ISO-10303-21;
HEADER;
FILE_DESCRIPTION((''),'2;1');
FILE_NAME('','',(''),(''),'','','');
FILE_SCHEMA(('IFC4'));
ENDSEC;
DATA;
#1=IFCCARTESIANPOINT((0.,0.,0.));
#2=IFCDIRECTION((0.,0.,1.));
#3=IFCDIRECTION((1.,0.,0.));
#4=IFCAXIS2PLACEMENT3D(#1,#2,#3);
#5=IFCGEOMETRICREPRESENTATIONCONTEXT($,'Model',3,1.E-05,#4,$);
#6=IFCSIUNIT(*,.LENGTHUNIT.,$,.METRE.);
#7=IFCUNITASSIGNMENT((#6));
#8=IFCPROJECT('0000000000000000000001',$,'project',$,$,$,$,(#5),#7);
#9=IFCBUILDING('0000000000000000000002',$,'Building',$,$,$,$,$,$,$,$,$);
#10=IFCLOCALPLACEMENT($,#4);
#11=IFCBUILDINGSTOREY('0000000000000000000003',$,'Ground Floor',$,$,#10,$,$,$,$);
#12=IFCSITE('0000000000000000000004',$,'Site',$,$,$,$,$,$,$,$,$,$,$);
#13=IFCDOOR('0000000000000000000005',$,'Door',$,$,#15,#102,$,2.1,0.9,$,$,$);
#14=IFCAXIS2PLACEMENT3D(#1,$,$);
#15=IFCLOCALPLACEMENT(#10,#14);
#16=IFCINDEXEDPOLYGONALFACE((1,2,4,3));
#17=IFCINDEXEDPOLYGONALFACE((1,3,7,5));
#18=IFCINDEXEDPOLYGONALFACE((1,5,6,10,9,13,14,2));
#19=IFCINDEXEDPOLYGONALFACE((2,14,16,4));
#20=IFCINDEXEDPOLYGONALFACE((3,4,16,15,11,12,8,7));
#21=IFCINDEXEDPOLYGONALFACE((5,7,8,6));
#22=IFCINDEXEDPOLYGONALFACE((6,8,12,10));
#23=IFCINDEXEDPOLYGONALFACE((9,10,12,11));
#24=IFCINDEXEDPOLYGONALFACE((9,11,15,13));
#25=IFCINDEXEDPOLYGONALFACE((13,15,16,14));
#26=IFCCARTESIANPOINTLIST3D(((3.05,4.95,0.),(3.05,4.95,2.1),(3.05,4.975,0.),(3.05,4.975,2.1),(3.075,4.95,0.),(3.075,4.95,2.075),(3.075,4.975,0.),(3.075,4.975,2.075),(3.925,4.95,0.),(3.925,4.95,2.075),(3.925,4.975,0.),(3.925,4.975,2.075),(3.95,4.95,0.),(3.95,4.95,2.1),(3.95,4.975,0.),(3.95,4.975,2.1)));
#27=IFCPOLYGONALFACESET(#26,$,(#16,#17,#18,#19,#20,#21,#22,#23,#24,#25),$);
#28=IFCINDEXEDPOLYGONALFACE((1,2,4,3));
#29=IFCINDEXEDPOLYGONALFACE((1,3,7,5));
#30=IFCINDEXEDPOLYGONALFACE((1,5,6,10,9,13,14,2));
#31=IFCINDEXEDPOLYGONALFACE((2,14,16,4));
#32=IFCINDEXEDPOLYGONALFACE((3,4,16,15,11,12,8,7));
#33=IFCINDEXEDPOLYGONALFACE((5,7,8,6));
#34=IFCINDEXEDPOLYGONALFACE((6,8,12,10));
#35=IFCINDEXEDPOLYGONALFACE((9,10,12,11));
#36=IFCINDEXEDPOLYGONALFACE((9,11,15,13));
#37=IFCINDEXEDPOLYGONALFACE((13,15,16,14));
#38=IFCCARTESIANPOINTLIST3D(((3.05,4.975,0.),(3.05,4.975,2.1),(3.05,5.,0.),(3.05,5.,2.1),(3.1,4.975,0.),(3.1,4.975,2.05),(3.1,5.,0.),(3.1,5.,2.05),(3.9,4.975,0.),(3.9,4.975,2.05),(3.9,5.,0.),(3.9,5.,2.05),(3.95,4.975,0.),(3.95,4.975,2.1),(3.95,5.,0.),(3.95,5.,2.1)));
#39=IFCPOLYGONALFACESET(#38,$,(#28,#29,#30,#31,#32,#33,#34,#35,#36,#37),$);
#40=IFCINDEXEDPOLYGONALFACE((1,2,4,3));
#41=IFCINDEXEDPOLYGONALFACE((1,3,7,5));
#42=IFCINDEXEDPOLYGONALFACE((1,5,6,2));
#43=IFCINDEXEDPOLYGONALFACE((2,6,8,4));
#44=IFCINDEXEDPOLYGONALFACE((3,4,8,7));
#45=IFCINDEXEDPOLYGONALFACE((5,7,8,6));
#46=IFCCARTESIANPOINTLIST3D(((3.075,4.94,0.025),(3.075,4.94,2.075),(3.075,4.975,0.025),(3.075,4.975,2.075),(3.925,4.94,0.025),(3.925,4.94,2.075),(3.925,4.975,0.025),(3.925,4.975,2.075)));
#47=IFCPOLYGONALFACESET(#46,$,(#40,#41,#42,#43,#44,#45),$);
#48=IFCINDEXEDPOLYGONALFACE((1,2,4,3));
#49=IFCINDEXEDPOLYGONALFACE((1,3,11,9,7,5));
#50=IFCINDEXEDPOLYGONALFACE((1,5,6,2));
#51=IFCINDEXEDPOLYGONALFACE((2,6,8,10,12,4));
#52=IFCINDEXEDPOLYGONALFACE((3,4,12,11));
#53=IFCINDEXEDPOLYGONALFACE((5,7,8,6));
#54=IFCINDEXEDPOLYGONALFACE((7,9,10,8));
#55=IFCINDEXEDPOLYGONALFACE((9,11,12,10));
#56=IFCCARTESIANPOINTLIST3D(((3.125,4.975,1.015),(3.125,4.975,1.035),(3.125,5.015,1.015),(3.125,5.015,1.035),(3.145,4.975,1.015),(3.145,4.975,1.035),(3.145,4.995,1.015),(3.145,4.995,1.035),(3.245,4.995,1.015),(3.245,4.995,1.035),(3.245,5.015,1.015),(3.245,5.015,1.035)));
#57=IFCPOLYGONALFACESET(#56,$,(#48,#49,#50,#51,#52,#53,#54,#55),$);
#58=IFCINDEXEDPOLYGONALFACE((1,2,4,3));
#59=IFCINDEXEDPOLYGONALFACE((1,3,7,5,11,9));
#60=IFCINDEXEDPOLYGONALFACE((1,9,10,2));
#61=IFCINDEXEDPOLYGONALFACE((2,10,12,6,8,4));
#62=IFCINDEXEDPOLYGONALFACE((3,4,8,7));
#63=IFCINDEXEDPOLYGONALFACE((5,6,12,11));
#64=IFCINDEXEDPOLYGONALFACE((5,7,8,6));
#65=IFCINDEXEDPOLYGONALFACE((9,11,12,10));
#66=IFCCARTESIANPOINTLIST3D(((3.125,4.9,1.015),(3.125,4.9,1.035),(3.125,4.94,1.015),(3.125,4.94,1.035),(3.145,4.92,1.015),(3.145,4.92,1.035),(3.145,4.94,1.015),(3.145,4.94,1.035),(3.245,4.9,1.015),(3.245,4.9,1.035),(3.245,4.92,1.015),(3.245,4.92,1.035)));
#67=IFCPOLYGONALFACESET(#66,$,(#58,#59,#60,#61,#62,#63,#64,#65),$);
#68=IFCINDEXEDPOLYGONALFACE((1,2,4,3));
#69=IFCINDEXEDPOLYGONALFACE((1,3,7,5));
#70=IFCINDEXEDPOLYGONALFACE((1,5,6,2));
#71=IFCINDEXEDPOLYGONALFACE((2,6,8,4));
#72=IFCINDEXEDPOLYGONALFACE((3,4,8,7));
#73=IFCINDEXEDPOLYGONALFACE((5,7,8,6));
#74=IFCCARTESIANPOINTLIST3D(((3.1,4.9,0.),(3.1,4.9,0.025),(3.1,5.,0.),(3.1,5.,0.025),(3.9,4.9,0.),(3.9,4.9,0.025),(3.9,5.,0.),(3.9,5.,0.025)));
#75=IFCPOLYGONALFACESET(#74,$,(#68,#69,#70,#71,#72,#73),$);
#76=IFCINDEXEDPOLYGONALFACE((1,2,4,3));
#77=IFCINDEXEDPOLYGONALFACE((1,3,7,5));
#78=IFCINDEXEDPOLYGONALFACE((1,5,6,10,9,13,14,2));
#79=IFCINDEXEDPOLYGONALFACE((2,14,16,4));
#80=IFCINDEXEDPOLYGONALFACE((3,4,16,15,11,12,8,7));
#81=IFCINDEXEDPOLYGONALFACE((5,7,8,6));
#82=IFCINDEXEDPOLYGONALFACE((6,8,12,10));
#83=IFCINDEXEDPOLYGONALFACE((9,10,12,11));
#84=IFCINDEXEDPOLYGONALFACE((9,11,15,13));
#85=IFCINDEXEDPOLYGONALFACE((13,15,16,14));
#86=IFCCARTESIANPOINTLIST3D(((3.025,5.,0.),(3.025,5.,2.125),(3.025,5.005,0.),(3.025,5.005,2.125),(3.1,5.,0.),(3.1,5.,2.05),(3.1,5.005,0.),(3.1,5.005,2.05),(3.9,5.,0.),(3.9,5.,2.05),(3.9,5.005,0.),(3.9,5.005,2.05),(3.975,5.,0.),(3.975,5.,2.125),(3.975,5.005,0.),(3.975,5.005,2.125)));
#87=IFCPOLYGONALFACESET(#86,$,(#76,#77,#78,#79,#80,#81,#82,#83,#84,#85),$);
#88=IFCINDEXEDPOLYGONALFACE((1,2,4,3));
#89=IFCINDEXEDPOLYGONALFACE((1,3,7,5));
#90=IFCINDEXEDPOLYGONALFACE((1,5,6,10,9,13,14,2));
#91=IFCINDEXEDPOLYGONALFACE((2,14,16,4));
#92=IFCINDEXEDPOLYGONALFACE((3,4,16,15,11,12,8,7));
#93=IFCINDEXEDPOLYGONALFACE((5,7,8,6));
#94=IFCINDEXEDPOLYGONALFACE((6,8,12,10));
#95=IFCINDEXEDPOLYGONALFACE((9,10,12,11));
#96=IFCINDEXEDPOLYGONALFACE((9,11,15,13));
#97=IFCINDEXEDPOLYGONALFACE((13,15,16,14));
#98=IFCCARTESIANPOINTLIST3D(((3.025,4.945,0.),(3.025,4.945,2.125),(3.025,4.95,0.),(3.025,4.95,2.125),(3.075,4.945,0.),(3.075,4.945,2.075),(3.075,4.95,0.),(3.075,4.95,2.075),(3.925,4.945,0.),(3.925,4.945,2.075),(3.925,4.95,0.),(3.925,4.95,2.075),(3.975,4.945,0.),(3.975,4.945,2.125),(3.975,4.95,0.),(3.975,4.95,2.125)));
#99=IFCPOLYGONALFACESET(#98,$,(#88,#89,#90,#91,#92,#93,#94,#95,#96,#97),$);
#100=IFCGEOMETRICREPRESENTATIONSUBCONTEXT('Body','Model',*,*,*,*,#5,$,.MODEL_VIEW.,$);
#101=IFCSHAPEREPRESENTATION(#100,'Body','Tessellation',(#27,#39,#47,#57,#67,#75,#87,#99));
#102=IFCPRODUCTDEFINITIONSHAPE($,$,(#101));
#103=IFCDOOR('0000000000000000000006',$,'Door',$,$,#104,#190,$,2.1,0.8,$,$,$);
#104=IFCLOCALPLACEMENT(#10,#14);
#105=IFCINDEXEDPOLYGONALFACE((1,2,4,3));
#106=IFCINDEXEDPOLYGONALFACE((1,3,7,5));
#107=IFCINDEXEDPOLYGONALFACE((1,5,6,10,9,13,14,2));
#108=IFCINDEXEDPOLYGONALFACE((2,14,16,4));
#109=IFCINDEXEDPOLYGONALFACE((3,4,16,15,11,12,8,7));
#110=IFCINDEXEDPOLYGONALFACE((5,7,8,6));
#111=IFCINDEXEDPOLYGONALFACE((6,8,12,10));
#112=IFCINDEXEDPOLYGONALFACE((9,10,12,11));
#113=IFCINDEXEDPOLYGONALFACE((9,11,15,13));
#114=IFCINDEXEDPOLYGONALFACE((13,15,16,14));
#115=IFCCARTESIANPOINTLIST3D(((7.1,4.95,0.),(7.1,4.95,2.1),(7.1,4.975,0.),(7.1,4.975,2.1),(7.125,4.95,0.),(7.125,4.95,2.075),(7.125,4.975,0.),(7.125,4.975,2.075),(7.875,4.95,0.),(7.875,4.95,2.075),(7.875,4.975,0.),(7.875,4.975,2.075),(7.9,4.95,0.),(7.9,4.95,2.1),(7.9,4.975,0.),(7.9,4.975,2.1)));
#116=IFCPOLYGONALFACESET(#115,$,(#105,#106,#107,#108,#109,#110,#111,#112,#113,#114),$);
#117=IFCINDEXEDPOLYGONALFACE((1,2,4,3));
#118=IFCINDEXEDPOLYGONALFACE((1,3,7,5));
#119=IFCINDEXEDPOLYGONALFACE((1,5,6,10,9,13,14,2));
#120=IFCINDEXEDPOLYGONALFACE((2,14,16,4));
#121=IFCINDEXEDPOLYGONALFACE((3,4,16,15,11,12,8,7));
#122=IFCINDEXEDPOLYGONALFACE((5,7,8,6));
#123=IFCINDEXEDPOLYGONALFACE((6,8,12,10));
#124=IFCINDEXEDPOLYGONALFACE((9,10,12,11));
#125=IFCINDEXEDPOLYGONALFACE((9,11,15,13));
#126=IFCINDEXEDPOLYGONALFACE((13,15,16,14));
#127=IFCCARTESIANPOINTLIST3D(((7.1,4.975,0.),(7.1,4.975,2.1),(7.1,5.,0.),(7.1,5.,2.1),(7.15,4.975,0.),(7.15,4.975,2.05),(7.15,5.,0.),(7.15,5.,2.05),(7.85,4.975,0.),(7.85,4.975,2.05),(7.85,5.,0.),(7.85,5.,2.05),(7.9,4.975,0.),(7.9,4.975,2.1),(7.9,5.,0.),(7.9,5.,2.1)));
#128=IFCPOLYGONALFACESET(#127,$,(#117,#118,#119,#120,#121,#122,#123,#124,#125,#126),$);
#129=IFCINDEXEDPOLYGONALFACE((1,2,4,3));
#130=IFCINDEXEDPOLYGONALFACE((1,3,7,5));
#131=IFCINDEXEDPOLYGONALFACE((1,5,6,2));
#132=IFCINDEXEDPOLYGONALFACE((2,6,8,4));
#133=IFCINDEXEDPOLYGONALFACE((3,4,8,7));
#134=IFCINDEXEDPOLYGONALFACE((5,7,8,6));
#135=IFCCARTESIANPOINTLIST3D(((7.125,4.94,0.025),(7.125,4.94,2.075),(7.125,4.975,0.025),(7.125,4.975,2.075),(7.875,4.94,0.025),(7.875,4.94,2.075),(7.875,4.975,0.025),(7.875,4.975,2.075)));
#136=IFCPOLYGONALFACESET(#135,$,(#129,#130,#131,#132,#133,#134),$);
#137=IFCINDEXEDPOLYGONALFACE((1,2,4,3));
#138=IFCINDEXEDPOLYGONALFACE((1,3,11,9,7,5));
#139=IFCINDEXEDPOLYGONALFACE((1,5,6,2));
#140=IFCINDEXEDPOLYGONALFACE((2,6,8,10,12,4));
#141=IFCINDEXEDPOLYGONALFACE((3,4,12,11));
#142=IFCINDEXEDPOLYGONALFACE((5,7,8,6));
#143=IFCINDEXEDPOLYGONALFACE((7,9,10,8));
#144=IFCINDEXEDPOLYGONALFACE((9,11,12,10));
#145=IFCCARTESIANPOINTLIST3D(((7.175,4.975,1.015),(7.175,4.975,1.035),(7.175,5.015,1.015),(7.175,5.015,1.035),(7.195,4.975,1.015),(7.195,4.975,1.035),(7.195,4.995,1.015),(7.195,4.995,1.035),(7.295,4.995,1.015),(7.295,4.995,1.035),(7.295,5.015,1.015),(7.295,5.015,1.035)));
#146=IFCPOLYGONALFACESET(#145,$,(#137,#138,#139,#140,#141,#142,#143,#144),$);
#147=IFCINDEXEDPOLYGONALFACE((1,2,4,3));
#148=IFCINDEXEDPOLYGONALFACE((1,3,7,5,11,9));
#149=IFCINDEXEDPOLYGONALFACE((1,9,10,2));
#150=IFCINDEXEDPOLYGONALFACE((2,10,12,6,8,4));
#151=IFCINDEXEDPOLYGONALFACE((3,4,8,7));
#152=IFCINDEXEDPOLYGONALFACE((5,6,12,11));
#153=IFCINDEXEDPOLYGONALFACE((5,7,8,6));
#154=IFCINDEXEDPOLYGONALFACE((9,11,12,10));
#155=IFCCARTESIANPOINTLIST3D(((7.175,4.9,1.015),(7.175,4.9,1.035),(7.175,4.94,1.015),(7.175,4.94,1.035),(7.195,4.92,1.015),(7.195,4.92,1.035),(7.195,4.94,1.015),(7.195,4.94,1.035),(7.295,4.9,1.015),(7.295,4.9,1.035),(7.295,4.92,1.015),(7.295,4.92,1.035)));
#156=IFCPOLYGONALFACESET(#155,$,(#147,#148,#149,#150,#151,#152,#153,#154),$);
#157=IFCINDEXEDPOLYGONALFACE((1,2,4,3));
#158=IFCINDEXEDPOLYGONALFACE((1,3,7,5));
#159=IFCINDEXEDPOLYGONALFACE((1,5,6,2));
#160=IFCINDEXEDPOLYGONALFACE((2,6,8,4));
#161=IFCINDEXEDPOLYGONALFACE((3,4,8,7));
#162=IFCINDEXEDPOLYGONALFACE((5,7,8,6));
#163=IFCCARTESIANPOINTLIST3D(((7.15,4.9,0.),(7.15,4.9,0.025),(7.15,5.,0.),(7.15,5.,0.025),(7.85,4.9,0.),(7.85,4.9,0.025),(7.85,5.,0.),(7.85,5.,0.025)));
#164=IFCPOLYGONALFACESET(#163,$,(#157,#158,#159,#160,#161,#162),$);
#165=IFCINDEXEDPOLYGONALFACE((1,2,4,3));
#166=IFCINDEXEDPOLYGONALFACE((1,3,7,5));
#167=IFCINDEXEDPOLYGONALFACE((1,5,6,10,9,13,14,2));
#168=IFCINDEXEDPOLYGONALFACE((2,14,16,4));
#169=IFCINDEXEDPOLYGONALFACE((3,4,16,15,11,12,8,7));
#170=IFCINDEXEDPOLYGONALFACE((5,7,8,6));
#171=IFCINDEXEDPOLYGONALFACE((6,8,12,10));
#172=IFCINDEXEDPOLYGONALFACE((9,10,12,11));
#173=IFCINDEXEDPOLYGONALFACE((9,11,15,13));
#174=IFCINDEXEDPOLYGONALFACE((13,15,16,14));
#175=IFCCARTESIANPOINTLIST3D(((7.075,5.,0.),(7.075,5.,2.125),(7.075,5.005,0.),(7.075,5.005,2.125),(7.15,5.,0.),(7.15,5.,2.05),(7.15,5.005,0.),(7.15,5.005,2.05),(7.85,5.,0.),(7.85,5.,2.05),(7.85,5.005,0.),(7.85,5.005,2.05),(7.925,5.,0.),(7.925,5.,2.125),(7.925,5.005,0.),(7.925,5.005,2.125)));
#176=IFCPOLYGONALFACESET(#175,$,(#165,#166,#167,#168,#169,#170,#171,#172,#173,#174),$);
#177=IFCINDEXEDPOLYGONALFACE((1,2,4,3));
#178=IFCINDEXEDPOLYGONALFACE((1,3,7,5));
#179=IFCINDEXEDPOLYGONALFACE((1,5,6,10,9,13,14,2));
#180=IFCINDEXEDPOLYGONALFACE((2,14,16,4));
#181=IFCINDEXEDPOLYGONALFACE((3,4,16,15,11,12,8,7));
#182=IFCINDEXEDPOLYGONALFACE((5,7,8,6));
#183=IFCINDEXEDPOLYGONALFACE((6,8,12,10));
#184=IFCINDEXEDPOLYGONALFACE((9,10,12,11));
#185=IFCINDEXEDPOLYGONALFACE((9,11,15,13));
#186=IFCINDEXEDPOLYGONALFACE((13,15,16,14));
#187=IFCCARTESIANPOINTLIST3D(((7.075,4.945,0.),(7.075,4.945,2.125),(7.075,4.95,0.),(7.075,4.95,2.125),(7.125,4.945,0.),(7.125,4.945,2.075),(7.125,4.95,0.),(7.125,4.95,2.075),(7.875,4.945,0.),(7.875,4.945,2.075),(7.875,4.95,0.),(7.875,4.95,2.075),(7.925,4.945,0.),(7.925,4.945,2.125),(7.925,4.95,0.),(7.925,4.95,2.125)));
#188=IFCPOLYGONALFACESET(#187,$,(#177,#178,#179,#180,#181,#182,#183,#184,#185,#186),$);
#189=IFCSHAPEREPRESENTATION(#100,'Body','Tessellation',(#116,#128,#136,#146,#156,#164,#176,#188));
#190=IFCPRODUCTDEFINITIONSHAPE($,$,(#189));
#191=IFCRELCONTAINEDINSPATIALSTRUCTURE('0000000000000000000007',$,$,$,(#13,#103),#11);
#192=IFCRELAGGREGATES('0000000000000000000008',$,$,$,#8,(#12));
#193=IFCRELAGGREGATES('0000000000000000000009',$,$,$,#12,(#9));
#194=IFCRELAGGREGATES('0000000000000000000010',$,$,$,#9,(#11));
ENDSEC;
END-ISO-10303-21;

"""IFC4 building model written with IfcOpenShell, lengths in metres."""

from ifc_helpers import new_model, si_unit, frame, origin_with_axes, place, context, subcontext, project, spatial, line, indexed_curve, outline, extrude, element, save


model = new_model("IFC4")

# Units and contexts
model_context = context("Model", 3, precision=1e-05, world=origin_with_axes())
body_context = subcontext(model_context, "Body", "Model", "MODEL_VIEW")
ifc_project = project(units=[si_unit("LENGTHUNIT", "METRE")], contexts=[model_context])

# Site, building, storey
site = spatial("IfcSite", under=ifc_project, Name="Site")
building = spatial("IfcBuilding", under=site, Name="Building")
storey_placement = place(None, origin_with_axes())
storey = spatial("IfcBuildingStorey", under=building, at=storey_placement, Name="Ground Floor")

# Doors
door_1_placement = place(storey_placement, frame((3.95, 5.0, 0.0), z_axis=(0.0, 0.0, 1.0), x_axis=(-1.0, 0.0, 0.0)))
element("IfcDoor", 1, at=door_1_placement, inside=storey, Name="Door", OverallHeight=2.1, OverallWidth=0.9, context=body_context, shape_type="SweptSolid", body=[
    extrude(outline(indexed_curve([(0.0, 0.0), (0.0, 2.1), (0.9, 2.1), (0.9, 0.0), (0.875, 0.0), (0.875, 2.075), (0.025, 2.075), (0.025, 0.0)], segments=[line(1, 2, 3, 4, 5, 6, 7, 8, 1)])), frame((0.0, 0.025, 0.0), z_axis=(0.0, -1.0, 0.0), x_axis=(1.0, 0.0, 0.0)), (0.0, 0.0, -1.0), 0.025),
    extrude(outline(indexed_curve([(0.0, 0.0), (0.0, 2.1), (0.9, 2.1), (0.9, 0.0), (0.85, 0.0), (0.85, 2.05), (0.05, 2.05), (0.05, 0.0)], segments=[line(1, 2, 3, 4, 5, 6, 7, 8, 1)])), frame((0.0, 0.0, 0.0), z_axis=(0.0, -1.0, 0.0), x_axis=(1.0, 0.0, 0.0)), (0.0, 0.0, -1.0), 0.025),
    extrude(outline(indexed_curve([(0.0, 0.0), (0.85, 0.0), (0.85, 0.035), (0.0, 0.035)], segments=[line(1, 2, 3, 4, 1)])), frame((0.025, 0.025, 0.025), z_axis=(0.0, 0.0, 1.0), x_axis=(1.0, 0.0, 0.0)), (0.0, 0.0, 1.0), 2.05),
    extrude(outline(indexed_curve([(0.0, 0.0), (0.0, -0.04), (-0.12, -0.04), (-0.12, -0.02), (-0.02, -0.02), (-0.02, 0.0)], segments=[line(1, 2, 3, 4, 5, 6, 1)])), frame((0.825, 0.025, 1.015), z_axis=(0.0, 0.0, 1.0), x_axis=(1.0, 0.0, 0.0)), (0.0, 0.0, 1.0), 0.02),
    extrude(outline(indexed_curve([(0.0, 0.0), (0.0, 0.04), (-0.12, 0.04), (-0.12, 0.02), (-0.02, 0.02), (-0.02, 0.0)], segments=[line(1, 2, 3, 4, 5, 6, 1)])), frame((0.825, 0.06, 1.015), z_axis=(0.0, 0.0, 1.0), x_axis=(1.0, 0.0, 0.0)), (0.0, 0.0, 1.0), 0.02),
    extrude(outline(indexed_curve([(0.0, 0.0), (0.8, 0.0), (0.8, 0.1), (0.0, 0.1)], segments=[line(1, 2, 3, 4, 1)])), frame((0.05, 0.0, 0.0), z_axis=(0.0, 0.0, 1.0), x_axis=(1.0, 0.0, 0.0)), (0.0, 0.0, 1.0), 0.025),
    extrude(outline(indexed_curve([(0.0, 0.0), (0.0, 2.125), (0.95, 2.125), (0.95, 0.0), (0.875, 0.0), (0.875, 2.05), (0.075, 2.05), (0.075, 0.0)], segments=[line(1, 2, 3, 4, 5, 6, 7, 8, 1)])), frame((-0.025, -0.005, 0.0), z_axis=(0.0, -1.0, 0.0), x_axis=(1.0, 0.0, 0.0)), (0.0, 0.0, -1.0), 0.005),
    extrude(outline(indexed_curve([(0.0, 0.0), (0.0, 2.125), (0.95, 2.125), (0.95, 0.0), (0.9, 0.0), (0.9, 2.075), (0.05, 2.075), (0.05, 0.0)], segments=[line(1, 2, 3, 4, 5, 6, 7, 8, 1)])), frame((-0.025, 0.05, 0.0), z_axis=(0.0, -1.0, 0.0), x_axis=(1.0, 0.0, 0.0)), (0.0, 0.0, -1.0), 0.005),
])
door_2_placement = place(storey_placement, frame((7.9, 5.0, 0.0), z_axis=(0.0, 0.0, 1.0), x_axis=(-1.0, 0.0, 0.0)))
element("IfcDoor", 2, at=door_2_placement, inside=storey, Name="Door", OverallHeight=2.1, OverallWidth=0.8, context=body_context, shape_type="SweptSolid", body=[
    extrude(outline(indexed_curve([(0.0, 0.0), (0.0, 2.1), (0.8, 2.1), (0.8, 0.0), (0.775, 0.0), (0.775, 2.075), (0.025, 2.075), (0.025, 0.0)], segments=[line(1, 2, 3, 4, 5, 6, 7, 8, 1)])), frame((0.0, 0.025, 0.0), z_axis=(0.0, -1.0, 0.0), x_axis=(1.0, 0.0, 0.0)), (0.0, 0.0, -1.0), 0.025),
    extrude(outline(indexed_curve([(0.0, 0.0), (0.0, 2.1), (0.8, 2.1), (0.8, 0.0), (0.75, 0.0), (0.75, 2.05), (0.05, 2.05), (0.05, 0.0)], segments=[line(1, 2, 3, 4, 5, 6, 7, 8, 1)])), frame((0.0, 0.0, 0.0), z_axis=(0.0, -1.0, 0.0), x_axis=(1.0, 0.0, 0.0)), (0.0, 0.0, -1.0), 0.025),
    extrude(outline(indexed_curve([(0.0, 0.0), (0.75, 0.0), (0.75, 0.035), (0.0, 0.035)], segments=[line(1, 2, 3, 4, 1)])), frame((0.025, 0.025, 0.025), z_axis=(0.0, 0.0, 1.0), x_axis=(1.0, 0.0, 0.0)), (0.0, 0.0, 1.0), 2.05),
    extrude(outline(indexed_curve([(0.0, 0.0), (0.0, -0.04), (-0.12, -0.04), (-0.12, -0.02), (-0.02, -0.02), (-0.02, 0.0)], segments=[line(1, 2, 3, 4, 5, 6, 1)])), frame((0.725, 0.025, 1.015), z_axis=(0.0, 0.0, 1.0), x_axis=(1.0, 0.0, 0.0)), (0.0, 0.0, 1.0), 0.02),
    extrude(outline(indexed_curve([(0.0, 0.0), (0.0, 0.04), (-0.12, 0.04), (-0.12, 0.02), (-0.02, 0.02), (-0.02, 0.0)], segments=[line(1, 2, 3, 4, 5, 6, 1)])), frame((0.725, 0.06, 1.015), z_axis=(0.0, 0.0, 1.0), x_axis=(1.0, 0.0, 0.0)), (0.0, 0.0, 1.0), 0.02),
    extrude(outline(indexed_curve([(0.0, 0.0), (0.7, 0.0), (0.7, 0.1), (0.0, 0.1)], segments=[line(1, 2, 3, 4, 1)])), frame((0.05, 0.0, 0.0), z_axis=(0.0, 0.0, 1.0), x_axis=(1.0, 0.0, 0.0)), (0.0, 0.0, 1.0), 0.025),
    extrude(outline(indexed_curve([(0.0, 0.0), (0.0, 2.125), (0.85, 2.125), (0.85, 0.0), (0.775, 0.0), (0.775, 2.05), (0.075, 2.05), (0.075, 0.0)], segments=[line(1, 2, 3, 4, 5, 6, 7, 8, 1)])), frame((-0.025, -0.005, 0.0), z_axis=(0.0, -1.0, 0.0), x_axis=(1.0, 0.0, 0.0)), (0.0, 0.0, -1.0), 0.005),
    extrude(outline(indexed_curve([(0.0, 0.0), (0.0, 2.125), (0.85, 2.125), (0.85, 0.0), (0.8, 0.0), (0.8, 2.075), (0.05, 2.075), (0.05, 0.0)], segments=[line(1, 2, 3, 4, 5, 6, 7, 8, 1)])), frame((-0.025, 0.05, 0.0), z_axis=(0.0, -1.0, 0.0), x_axis=(1.0, 0.0, 0.0)), (0.0, 0.0, -1.0), 0.005),
])

save(model, "model.ifc")
